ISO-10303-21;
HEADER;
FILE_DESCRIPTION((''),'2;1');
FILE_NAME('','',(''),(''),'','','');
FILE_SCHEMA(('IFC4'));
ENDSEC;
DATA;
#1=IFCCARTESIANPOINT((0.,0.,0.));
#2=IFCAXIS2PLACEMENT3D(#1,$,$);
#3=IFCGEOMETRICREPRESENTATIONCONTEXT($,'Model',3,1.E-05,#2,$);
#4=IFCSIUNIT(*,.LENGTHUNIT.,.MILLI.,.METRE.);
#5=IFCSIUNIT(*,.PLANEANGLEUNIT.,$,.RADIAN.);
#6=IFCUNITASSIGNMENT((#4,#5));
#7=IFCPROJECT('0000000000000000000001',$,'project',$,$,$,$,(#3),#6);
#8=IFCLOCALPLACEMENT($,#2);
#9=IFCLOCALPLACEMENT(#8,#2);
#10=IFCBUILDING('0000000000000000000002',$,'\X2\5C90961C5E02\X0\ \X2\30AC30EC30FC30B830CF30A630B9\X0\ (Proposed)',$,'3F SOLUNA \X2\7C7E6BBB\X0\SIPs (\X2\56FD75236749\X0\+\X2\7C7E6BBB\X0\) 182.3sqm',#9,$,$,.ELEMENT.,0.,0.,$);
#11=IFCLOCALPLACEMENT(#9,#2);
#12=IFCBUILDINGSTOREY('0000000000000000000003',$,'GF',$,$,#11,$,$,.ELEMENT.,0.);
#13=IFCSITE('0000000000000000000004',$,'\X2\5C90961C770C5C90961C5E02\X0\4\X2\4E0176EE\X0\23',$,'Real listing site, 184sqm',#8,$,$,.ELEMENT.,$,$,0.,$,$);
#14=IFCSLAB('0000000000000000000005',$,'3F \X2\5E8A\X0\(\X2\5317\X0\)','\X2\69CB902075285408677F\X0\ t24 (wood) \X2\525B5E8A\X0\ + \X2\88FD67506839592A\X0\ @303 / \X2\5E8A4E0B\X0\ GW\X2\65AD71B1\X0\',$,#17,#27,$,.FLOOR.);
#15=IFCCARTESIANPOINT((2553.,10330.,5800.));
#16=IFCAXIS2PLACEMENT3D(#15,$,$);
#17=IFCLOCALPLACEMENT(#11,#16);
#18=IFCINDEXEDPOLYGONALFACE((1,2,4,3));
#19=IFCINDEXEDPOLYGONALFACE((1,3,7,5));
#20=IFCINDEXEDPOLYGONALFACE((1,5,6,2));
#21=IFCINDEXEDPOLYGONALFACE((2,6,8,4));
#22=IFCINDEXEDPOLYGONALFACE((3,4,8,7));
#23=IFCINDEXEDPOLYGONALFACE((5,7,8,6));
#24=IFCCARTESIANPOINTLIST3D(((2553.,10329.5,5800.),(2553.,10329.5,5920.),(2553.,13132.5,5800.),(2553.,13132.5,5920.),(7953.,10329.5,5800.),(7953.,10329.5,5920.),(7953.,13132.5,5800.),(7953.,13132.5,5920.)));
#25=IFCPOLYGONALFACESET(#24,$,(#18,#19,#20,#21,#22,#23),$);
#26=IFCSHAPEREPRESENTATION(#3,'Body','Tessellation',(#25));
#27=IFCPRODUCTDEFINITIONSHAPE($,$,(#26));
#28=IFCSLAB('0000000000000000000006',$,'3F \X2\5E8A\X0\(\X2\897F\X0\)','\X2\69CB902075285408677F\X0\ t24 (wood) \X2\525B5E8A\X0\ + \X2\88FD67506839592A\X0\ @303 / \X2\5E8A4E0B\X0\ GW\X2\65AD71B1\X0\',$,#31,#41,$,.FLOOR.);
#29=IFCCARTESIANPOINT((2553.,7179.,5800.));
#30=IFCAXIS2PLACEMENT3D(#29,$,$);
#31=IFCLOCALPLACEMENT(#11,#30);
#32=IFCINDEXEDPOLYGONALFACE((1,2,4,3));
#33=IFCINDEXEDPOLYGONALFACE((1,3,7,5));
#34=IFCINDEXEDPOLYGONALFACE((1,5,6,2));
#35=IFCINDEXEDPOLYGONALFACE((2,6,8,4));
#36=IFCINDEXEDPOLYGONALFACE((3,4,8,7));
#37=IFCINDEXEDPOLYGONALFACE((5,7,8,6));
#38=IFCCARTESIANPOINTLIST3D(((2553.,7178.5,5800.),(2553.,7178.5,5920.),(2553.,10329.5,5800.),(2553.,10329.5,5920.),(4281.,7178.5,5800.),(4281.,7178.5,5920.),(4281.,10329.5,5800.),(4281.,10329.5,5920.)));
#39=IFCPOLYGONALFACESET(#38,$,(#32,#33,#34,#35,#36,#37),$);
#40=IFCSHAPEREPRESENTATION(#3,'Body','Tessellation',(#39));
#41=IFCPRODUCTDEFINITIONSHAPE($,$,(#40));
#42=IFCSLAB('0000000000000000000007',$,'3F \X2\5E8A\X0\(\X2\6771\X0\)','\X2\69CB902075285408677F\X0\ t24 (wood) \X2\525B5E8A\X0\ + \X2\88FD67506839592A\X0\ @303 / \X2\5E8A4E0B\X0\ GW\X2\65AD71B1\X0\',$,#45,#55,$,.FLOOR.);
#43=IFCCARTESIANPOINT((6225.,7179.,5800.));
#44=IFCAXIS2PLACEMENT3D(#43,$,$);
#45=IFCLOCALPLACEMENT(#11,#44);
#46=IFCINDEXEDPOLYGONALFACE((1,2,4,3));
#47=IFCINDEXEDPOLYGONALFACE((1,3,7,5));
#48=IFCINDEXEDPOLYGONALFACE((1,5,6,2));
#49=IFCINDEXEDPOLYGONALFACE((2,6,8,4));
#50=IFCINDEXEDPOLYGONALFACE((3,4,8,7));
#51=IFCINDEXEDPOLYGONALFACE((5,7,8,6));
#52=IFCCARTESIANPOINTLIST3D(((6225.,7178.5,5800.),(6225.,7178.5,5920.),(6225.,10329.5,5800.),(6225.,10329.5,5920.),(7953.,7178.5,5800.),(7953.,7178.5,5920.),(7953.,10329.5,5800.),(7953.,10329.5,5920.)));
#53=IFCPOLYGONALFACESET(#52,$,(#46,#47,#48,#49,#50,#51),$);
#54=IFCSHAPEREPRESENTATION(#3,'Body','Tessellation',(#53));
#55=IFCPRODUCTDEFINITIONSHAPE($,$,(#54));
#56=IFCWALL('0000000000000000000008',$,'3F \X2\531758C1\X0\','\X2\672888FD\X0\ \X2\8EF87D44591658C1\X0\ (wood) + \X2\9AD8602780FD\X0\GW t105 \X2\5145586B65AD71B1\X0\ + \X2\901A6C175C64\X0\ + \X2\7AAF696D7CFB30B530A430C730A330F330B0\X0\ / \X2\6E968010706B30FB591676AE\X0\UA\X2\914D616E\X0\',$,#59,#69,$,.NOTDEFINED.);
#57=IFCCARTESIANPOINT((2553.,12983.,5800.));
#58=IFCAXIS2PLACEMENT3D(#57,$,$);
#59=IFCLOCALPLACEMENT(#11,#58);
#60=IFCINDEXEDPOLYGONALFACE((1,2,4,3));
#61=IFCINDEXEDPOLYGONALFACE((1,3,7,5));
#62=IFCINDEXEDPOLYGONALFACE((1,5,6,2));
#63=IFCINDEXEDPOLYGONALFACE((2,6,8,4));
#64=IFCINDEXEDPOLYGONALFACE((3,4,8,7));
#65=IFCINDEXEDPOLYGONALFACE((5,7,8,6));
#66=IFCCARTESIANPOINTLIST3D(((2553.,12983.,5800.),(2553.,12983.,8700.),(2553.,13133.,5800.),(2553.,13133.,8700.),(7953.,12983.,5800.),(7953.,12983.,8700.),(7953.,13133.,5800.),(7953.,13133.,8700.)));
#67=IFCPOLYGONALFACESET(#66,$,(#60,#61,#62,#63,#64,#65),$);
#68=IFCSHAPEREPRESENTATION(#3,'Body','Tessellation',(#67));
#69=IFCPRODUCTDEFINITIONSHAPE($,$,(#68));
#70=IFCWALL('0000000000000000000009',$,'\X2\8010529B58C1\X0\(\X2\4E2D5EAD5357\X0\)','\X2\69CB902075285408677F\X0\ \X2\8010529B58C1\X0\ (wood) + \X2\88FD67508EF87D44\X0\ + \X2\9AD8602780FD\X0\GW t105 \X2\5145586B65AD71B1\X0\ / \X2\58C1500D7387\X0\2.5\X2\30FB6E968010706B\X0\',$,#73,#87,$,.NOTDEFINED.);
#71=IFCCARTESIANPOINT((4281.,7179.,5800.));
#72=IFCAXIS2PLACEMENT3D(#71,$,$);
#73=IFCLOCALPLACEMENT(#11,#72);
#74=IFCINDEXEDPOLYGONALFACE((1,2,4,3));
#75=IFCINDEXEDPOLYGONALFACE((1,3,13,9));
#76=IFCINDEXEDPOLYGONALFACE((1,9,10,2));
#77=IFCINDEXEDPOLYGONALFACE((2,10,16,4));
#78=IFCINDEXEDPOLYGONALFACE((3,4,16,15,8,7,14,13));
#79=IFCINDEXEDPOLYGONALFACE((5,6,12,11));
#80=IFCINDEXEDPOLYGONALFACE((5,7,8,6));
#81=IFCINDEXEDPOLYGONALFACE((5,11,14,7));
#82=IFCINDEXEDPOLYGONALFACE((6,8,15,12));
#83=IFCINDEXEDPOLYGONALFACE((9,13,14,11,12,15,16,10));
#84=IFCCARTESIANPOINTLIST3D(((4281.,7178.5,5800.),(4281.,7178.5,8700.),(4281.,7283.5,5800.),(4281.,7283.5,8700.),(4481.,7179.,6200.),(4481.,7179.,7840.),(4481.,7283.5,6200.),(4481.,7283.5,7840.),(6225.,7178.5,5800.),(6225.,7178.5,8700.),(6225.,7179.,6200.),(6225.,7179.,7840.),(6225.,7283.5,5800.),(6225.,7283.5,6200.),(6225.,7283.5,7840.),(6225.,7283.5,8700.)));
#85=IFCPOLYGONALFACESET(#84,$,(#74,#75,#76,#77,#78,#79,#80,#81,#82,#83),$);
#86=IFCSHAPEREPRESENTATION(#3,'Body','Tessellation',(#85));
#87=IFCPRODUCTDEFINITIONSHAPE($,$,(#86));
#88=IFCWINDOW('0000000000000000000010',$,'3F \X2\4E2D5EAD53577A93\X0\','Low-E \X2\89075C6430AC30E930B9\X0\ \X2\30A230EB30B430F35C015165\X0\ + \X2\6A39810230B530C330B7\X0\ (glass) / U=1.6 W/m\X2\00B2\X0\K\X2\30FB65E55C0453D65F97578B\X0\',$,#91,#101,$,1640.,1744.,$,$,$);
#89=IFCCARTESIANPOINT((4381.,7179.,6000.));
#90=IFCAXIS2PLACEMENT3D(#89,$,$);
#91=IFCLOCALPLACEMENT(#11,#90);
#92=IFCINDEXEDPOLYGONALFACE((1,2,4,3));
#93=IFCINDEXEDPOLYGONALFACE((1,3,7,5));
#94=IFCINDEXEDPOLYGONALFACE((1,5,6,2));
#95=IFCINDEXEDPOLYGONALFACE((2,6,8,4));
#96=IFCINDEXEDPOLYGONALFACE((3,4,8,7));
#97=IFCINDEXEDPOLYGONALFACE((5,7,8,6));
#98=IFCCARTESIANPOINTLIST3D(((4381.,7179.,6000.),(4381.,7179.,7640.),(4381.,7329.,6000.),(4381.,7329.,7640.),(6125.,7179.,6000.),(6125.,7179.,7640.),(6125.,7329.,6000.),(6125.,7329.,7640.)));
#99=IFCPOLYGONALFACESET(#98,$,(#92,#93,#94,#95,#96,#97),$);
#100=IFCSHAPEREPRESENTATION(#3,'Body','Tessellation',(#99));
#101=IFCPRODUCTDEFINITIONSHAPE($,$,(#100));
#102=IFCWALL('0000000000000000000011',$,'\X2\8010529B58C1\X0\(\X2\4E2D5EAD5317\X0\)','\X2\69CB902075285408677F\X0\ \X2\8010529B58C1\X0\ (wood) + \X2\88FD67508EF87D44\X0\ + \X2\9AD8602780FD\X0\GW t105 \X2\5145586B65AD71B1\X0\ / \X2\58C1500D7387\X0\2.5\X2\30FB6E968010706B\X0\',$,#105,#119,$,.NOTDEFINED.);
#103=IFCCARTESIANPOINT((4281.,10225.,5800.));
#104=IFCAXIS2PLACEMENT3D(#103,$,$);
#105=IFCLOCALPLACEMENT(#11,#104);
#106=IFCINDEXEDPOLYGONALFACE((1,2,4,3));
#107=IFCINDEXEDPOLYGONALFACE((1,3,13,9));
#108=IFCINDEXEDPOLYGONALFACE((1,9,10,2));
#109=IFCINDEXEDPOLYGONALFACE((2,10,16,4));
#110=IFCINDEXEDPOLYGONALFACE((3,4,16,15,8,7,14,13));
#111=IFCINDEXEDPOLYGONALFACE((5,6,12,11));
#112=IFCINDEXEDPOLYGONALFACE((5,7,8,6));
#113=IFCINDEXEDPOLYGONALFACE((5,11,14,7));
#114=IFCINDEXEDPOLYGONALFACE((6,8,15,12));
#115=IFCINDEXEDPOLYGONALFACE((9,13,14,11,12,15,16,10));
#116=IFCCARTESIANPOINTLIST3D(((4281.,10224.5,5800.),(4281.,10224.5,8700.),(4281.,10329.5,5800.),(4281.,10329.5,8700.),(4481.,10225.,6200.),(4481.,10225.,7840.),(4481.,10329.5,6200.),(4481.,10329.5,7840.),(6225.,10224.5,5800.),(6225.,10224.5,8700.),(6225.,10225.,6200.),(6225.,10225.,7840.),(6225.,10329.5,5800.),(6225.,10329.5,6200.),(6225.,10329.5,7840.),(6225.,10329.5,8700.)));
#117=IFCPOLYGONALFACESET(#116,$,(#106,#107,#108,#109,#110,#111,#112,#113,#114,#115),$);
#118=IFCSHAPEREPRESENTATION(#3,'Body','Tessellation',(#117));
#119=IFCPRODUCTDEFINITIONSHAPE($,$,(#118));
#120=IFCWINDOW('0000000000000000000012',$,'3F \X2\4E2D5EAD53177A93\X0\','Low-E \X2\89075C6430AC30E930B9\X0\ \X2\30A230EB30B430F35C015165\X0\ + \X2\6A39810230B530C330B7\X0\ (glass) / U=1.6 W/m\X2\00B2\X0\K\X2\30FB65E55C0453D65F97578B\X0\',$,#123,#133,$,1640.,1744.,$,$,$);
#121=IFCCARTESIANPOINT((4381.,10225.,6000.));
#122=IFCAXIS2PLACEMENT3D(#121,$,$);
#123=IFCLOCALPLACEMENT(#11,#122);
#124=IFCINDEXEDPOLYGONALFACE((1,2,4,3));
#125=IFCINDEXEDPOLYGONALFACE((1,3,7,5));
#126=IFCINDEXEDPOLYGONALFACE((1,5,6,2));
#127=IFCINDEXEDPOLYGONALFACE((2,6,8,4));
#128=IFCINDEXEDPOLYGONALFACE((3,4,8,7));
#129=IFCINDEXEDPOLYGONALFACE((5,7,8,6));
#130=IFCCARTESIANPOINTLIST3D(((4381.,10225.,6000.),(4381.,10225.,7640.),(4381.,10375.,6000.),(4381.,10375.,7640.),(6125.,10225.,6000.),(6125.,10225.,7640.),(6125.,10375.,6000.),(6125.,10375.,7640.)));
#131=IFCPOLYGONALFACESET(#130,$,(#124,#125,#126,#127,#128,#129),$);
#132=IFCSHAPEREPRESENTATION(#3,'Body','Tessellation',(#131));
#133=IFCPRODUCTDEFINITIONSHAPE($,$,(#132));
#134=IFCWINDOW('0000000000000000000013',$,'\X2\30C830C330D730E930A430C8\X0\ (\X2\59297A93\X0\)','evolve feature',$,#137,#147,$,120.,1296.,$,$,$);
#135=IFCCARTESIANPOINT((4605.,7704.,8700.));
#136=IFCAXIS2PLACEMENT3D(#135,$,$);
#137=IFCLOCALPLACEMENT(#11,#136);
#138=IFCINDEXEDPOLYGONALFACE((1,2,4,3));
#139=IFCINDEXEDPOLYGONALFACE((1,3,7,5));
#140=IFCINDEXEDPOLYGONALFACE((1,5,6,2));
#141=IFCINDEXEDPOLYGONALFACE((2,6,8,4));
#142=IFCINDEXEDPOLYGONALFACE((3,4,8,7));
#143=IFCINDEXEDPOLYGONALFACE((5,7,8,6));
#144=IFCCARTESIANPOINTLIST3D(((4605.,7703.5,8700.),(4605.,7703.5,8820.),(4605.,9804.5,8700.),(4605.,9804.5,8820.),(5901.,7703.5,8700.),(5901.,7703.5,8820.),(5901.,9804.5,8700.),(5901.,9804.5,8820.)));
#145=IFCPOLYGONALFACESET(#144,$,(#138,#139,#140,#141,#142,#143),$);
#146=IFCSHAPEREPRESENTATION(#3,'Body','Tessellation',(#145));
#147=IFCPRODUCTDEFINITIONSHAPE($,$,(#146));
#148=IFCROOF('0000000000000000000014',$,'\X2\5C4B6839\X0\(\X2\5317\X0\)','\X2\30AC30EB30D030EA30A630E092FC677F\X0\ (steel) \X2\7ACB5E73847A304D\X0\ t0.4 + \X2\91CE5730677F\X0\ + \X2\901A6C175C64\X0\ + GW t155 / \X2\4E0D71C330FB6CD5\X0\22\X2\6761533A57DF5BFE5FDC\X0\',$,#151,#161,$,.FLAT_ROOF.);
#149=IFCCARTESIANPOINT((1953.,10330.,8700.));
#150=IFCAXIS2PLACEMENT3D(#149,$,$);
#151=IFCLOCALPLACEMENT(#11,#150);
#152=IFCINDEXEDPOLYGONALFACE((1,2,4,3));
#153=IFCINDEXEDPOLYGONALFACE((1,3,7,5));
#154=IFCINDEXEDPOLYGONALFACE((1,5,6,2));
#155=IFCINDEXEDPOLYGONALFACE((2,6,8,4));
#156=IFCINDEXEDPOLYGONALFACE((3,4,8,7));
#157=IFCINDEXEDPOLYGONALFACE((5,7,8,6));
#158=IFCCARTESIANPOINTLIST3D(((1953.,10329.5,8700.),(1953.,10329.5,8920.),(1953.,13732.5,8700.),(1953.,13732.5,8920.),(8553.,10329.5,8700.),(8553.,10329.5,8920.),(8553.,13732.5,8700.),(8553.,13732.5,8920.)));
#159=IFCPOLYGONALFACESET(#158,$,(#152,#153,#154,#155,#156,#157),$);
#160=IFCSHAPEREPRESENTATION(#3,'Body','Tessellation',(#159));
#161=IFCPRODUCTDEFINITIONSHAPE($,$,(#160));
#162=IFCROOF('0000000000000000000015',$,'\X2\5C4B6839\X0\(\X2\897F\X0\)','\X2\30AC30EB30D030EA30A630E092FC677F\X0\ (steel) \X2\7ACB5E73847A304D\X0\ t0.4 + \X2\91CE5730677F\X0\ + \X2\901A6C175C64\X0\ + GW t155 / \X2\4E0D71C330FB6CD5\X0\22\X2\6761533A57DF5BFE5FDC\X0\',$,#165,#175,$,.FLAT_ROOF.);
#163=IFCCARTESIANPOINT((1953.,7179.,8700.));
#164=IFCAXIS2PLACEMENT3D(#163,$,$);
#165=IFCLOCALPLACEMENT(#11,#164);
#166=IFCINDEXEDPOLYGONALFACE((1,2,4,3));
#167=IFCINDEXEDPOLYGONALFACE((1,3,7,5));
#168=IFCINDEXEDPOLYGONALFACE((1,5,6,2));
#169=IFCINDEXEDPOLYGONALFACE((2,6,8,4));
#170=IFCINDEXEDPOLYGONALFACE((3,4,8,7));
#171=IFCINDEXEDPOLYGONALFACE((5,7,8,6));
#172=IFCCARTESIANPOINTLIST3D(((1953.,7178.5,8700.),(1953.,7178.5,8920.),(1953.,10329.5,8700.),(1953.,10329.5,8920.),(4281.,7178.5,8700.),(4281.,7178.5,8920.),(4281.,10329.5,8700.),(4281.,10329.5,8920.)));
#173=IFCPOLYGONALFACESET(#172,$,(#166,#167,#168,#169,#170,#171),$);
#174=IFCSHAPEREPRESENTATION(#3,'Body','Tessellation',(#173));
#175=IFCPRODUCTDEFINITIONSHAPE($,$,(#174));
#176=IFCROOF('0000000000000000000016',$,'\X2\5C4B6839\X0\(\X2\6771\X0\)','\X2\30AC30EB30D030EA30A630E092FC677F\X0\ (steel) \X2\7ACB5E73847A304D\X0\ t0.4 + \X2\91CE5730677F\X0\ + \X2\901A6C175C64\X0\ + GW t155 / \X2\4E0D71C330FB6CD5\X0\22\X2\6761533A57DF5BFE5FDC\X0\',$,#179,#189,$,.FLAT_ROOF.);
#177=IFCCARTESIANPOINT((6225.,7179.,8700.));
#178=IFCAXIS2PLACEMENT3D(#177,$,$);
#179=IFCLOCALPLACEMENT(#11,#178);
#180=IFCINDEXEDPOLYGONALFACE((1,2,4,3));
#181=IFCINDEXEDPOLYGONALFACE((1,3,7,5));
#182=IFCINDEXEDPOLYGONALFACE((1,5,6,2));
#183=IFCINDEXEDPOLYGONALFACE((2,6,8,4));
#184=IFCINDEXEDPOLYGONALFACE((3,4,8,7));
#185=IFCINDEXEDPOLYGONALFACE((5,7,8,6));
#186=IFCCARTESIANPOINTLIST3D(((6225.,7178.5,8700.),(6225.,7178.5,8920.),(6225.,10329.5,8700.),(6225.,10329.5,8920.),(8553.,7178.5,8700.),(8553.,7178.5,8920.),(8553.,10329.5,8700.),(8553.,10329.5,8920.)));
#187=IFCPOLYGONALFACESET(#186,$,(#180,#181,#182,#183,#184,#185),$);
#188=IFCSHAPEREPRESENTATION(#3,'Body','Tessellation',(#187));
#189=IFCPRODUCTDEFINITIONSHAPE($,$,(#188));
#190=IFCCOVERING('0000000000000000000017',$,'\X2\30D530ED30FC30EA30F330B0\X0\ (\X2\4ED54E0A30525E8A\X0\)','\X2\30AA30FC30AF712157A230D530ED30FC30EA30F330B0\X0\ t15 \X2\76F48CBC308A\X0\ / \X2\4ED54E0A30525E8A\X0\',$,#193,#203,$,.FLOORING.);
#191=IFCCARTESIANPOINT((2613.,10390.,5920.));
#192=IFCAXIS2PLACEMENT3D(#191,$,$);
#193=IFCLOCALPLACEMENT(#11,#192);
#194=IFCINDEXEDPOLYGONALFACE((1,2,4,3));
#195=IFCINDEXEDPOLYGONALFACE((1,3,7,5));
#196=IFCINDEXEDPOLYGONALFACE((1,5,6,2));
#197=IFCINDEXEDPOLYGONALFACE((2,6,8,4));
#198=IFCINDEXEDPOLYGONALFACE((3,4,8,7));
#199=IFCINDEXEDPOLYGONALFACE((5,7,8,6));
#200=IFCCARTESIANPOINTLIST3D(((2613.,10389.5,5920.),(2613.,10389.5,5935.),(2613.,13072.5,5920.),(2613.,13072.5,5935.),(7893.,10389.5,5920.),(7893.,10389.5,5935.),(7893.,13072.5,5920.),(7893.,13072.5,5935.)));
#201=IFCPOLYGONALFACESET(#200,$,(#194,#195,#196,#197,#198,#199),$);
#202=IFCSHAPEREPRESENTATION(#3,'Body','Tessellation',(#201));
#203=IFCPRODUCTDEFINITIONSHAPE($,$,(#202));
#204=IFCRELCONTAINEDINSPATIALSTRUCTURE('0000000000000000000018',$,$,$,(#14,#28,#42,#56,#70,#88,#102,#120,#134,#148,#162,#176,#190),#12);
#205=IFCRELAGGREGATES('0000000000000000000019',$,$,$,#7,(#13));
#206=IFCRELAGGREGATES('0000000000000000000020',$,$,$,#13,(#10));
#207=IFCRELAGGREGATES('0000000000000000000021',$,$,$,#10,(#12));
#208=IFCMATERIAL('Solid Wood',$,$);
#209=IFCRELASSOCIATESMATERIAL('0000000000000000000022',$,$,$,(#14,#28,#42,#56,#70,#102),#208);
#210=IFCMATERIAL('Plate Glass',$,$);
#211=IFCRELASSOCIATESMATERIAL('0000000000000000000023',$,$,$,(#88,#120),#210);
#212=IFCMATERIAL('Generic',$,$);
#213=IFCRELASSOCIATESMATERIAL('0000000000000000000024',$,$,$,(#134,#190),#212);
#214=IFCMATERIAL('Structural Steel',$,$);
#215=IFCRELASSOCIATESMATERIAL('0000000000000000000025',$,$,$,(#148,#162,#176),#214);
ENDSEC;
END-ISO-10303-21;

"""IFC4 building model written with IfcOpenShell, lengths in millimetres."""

from ifc_helpers import new_model, si_unit, frame, frame_2d, origin, place, context, project, spatial, rectangle, extrude, material, element, fill, save


model = new_model("IFC4")

# Units and contexts
model_context = context("Model", 3, precision=1e-05, world=origin())
ifc_project = project(units=[si_unit("LENGTHUNIT", "METRE", prefix="MILLI"), si_unit("PLANEANGLEUNIT", "RADIAN")], contexts=[model_context])

# Site, building, storey
site_placement = place(None, origin())
site = spatial("IfcSite", under=ifc_project, at=site_placement, Name="岐阜県岐阜市4丁目23", ObjectType="Real listing site, 184sqm", CompositionType="ELEMENT", RefElevation=0.0)
building_placement = place(site_placement, origin())
building = spatial("IfcBuilding", under=site, at=building_placement, Name="岐阜市 ガレージハウス (Proposed)", ObjectType="3F SOLUNA 籾殻SIPs (国産杉+籾殻) 182.3sqm", CompositionType="ELEMENT", ElevationOfRefHeight=0.0, ElevationOfTerrain=0.0)
storey_placement = place(building_placement, origin())
storey = spatial("IfcBuildingStorey", under=building, at=storey_placement, Name="GF", CompositionType="ELEMENT", Elevation=0.0)

# Slabs
ifc_material_1 = material(Name="Solid Wood")
slab_1_placement = place(storey_placement, frame((2553.0, 10330.0, 5800.0)))
element("IfcSlab", 1, at=slab_1_placement, inside=storey, material=ifc_material_1, Name="3F 床(北)", Description="構造用合板 t24 (wood) 剛床 + 製材根太 @303 / 床下 GW断熱", PredefinedType="FLOOR", context=model_context, shape_type="SweptSolid", body=[
    extrude(rectangle(XDim=5400.0, YDim=2803.0, at=frame_2d((2700.0, 1401.0))), frame((2553.0, 10330.0, 5800.0)), (0.0, 0.0, 1.0), 120.0),
])
slab_2_placement = place(storey_placement, frame((2553.0, 7179.0, 5800.0)))
element("IfcSlab", 2, at=slab_2_placement, inside=storey, material=ifc_material_1, Name="3F 床(西)", Description="構造用合板 t24 (wood) 剛床 + 製材根太 @303 / 床下 GW断熱", PredefinedType="FLOOR", context=model_context, shape_type="SweptSolid", body=[
    extrude(rectangle(XDim=1728.0, YDim=3151.0, at=frame_2d((864.0, 1575.0))), frame((2553.0, 7179.0, 5800.0)), (0.0, 0.0, 1.0), 120.0),
])
slab_3_placement = place(storey_placement, frame((6225.0, 7179.0, 5800.0)))
element("IfcSlab", 3, at=slab_3_placement, inside=storey, material=ifc_material_1, Name="3F 床(東)", Description="構造用合板 t24 (wood) 剛床 + 製材根太 @303 / 床下 GW断熱", PredefinedType="FLOOR", context=model_context, shape_type="SweptSolid", body=[
    extrude(rectangle(XDim=1728.0, YDim=3151.0, at=frame_2d((864.0, 1575.0))), frame((6225.0, 7179.0, 5800.0)), (0.0, 0.0, 1.0), 120.0),
])

# Wall
wall_1_placement = place(storey_placement, frame((2553.0, 12983.0, 5800.0)))
element("IfcWall", 4, at=wall_1_placement, inside=storey, material=ifc_material_1, Name="3F 北壁", Description="木製 軸組外壁 (wood) + 高性能GW t105 充填断熱 + 通気層 + 窯業系サイディング / 準耐火・外皮UA配慮", PredefinedType="NOTDEFINED", context=model_context, shape_type="SweptSolid", body=[
    extrude(rectangle(XDim=5400.0, YDim=150.0, at=frame_2d((2700.0, 75.0))), frame((2553.0, 12983.0, 5800.0)), (0.0, 0.0, 1.0), 2900.0),
])

# Walls, openings, windows
wall_2_placement = place(storey_placement, frame((4281.0, 7179.0, 5800.0)))
wall_2 = element("IfcWall", 5, at=wall_2_placement, inside=storey, material=ifc_material_1, Name="耐力壁(中庭南)", Description="構造用合板 耐力壁 (wood) + 製材軸組 + 高性能GW t105 充填断熱 / 壁倍率2.5・準耐火", PredefinedType="NOTDEFINED", context=model_context, shape_type="SweptSolid", body=[
    extrude(rectangle(XDim=1944.0, YDim=105.0, at=frame_2d((972.0, 52.0))), frame((4281.0, 7179.0, 5800.0)), (0.0, 0.0, 1.0), 2900.0),
])
opening_1_placement = place(storey_placement, frame((4381.0, 7179.0, 6000.0)))
opening_1 = element("IfcOpeningElement", 6, at=opening_1_placement, cuts=wall_2, PredefinedType="NOTDEFINED", context=model_context, shape_type="SweptSolid", body=[
    extrude(rectangle(XDim=1744.0, YDim=150.0, at=frame_2d((872.0, 75.0))), frame((4381.0, 7179.0, 6000.0)), (0.0, 0.0, 1.0), 1640.0),
])
ifc_material_2 = material(Name="Plate Glass")
window_1_placement = place(storey_placement, frame((4381.0, 7179.0, 6000.0)))
window_1 = element("IfcWindow", 7, at=window_1_placement, inside=storey, material=ifc_material_2, Name="3F 中庭南窓", Description="Low-E 複層ガラス アルゴン封入 + 樹脂サッシ (glass) / U=1.6 W/m²K・日射取得型", OverallHeight=1640.0, OverallWidth=1744.0, context=model_context, shape_type="SweptSolid", body=[
    extrude(rectangle(XDim=1744.0, YDim=150.0, at=frame_2d((872.0, 75.0))), frame((4381.0, 7179.0, 6000.0)), (0.0, 0.0, 1.0), 1640.0),
])
fill(opening_1, window_1)
wall_3_placement = place(storey_placement, frame((4281.0, 10225.0, 5800.0)))
wall_3 = element("IfcWall", 8, at=wall_3_placement, inside=storey, material=ifc_material_1, Name="耐力壁(中庭北)", Description="構造用合板 耐力壁 (wood) + 製材軸組 + 高性能GW t105 充填断熱 / 壁倍率2.5・準耐火", PredefinedType="NOTDEFINED", context=model_context, shape_type="SweptSolid", body=[
    extrude(rectangle(XDim=1944.0, YDim=105.0, at=frame_2d((972.0, 52.0))), frame((4281.0, 10225.0, 5800.0)), (0.0, 0.0, 1.0), 2900.0),
])
opening_2_placement = place(storey_placement, frame((4381.0, 10225.0, 6000.0)))
opening_2 = element("IfcOpeningElement", 9, at=opening_2_placement, cuts=wall_3, PredefinedType="NOTDEFINED", context=model_context, shape_type="SweptSolid", body=[
    extrude(rectangle(XDim=1744.0, YDim=150.0, at=frame_2d((872.0, 75.0))), frame((4381.0, 10225.0, 6000.0)), (0.0, 0.0, 1.0), 1640.0),
])
window_2_placement = place(storey_placement, frame((4381.0, 10225.0, 6000.0)))
window_2 = element("IfcWindow", 10, at=window_2_placement, inside=storey, material=ifc_material_2, Name="3F 中庭北窓", Description="Low-E 複層ガラス アルゴン封入 + 樹脂サッシ (glass) / U=1.6 W/m²K・日射取得型", OverallHeight=1640.0, OverallWidth=1744.0, context=model_context, shape_type="SweptSolid", body=[
    extrude(rectangle(XDim=1744.0, YDim=150.0, at=frame_2d((872.0, 75.0))), frame((4381.0, 10225.0, 6000.0)), (0.0, 0.0, 1.0), 1640.0),
])
fill(opening_2, window_2)

# Window
ifc_material_3 = material(Name="Generic")
window_3_placement = place(storey_placement, frame((4605.0, 7704.0, 8700.0)))
element("IfcWindow", 11, at=window_3_placement, inside=storey, material=ifc_material_3, Name="トップライト (天窓)", Description="evolve feature", OverallHeight=120.0, OverallWidth=1296.0, context=model_context, shape_type="SweptSolid", body=[
    extrude(rectangle(XDim=1296.0, YDim=2101.0, at=frame_2d((648.0, 1050.0))), frame((4605.0, 7704.0, 8700.0)), (0.0, 0.0, 1.0), 120.0),
])

# Roofs
ifc_material_4 = material(Name="Structural Steel")
for number, where, name in (
    (12, (1953.0, 10330.0, 8700.0), "屋根(北)"),
):
    element("IfcRoof", number, at=place(storey_placement, frame(where)), inside=storey, material=ifc_material_4, Name=name, Description="ガルバリウム鋼板 (steel) 立平葺き t0.4 + 野地板 + 通気層 + GW t155 / 不燃・法22条区域対応", PredefinedType="FLAT_ROOF", context=model_context, shape_type="SweptSolid", body=[
        extrude(rectangle(XDim=6600.0, YDim=3403.0, at=frame_2d((3300.0, 1701.0))), frame((1953.0, 10330.0, 8700.0)), (0.0, 0.0, 1.0), 220.0),
    ])
roof_1_placement = place(storey_placement, frame((1953.0, 7179.0, 8700.0)))
element("IfcRoof", 13, at=roof_1_placement, inside=storey, material=ifc_material_4, Name="屋根(西)", Description="ガルバリウム鋼板 (steel) 立平葺き t0.4 + 野地板 + 通気層 + GW t155 / 不燃・法22条区域対応", PredefinedType="FLAT_ROOF", context=model_context, shape_type="SweptSolid", body=[
    extrude(rectangle(XDim=2328.0, YDim=3151.0, at=frame_2d((1164.0, 1575.0))), frame((1953.0, 7179.0, 8700.0)), (0.0, 0.0, 1.0), 220.0),
])
roof_2_placement = place(storey_placement, frame((6225.0, 7179.0, 8700.0)))
element("IfcRoof", 14, at=roof_2_placement, inside=storey, material=ifc_material_4, Name="屋根(東)", Description="ガルバリウム鋼板 (steel) 立平葺き t0.4 + 野地板 + 通気層 + GW t155 / 不燃・法22条区域対応", PredefinedType="FLAT_ROOF", context=model_context, shape_type="SweptSolid", body=[
    extrude(rectangle(XDim=2328.0, YDim=3151.0, at=frame_2d((1164.0, 1575.0))), frame((6225.0, 7179.0, 8700.0)), (0.0, 0.0, 1.0), 220.0),
])

# Covering
covering_1_placement = place(storey_placement, frame((2613.0, 10390.0, 5920.0)))
element("IfcCovering", 15, at=covering_1_placement, inside=storey, material=ifc_material_3, Name="フローリング (仕上げ床)", Description="オーク無垢フローリング t15 直貼り / 仕上げ床", PredefinedType="FLOORING", context=model_context, shape_type="SweptSolid", body=[
    extrude(rectangle(XDim=5280.0, YDim=2683.0, at=frame_2d((2640.0, 1341.0))), frame((2613.0, 10390.0, 5920.0)), (0.0, 0.0, 1.0), 15.0),
])

save(model, "model.ifc")
